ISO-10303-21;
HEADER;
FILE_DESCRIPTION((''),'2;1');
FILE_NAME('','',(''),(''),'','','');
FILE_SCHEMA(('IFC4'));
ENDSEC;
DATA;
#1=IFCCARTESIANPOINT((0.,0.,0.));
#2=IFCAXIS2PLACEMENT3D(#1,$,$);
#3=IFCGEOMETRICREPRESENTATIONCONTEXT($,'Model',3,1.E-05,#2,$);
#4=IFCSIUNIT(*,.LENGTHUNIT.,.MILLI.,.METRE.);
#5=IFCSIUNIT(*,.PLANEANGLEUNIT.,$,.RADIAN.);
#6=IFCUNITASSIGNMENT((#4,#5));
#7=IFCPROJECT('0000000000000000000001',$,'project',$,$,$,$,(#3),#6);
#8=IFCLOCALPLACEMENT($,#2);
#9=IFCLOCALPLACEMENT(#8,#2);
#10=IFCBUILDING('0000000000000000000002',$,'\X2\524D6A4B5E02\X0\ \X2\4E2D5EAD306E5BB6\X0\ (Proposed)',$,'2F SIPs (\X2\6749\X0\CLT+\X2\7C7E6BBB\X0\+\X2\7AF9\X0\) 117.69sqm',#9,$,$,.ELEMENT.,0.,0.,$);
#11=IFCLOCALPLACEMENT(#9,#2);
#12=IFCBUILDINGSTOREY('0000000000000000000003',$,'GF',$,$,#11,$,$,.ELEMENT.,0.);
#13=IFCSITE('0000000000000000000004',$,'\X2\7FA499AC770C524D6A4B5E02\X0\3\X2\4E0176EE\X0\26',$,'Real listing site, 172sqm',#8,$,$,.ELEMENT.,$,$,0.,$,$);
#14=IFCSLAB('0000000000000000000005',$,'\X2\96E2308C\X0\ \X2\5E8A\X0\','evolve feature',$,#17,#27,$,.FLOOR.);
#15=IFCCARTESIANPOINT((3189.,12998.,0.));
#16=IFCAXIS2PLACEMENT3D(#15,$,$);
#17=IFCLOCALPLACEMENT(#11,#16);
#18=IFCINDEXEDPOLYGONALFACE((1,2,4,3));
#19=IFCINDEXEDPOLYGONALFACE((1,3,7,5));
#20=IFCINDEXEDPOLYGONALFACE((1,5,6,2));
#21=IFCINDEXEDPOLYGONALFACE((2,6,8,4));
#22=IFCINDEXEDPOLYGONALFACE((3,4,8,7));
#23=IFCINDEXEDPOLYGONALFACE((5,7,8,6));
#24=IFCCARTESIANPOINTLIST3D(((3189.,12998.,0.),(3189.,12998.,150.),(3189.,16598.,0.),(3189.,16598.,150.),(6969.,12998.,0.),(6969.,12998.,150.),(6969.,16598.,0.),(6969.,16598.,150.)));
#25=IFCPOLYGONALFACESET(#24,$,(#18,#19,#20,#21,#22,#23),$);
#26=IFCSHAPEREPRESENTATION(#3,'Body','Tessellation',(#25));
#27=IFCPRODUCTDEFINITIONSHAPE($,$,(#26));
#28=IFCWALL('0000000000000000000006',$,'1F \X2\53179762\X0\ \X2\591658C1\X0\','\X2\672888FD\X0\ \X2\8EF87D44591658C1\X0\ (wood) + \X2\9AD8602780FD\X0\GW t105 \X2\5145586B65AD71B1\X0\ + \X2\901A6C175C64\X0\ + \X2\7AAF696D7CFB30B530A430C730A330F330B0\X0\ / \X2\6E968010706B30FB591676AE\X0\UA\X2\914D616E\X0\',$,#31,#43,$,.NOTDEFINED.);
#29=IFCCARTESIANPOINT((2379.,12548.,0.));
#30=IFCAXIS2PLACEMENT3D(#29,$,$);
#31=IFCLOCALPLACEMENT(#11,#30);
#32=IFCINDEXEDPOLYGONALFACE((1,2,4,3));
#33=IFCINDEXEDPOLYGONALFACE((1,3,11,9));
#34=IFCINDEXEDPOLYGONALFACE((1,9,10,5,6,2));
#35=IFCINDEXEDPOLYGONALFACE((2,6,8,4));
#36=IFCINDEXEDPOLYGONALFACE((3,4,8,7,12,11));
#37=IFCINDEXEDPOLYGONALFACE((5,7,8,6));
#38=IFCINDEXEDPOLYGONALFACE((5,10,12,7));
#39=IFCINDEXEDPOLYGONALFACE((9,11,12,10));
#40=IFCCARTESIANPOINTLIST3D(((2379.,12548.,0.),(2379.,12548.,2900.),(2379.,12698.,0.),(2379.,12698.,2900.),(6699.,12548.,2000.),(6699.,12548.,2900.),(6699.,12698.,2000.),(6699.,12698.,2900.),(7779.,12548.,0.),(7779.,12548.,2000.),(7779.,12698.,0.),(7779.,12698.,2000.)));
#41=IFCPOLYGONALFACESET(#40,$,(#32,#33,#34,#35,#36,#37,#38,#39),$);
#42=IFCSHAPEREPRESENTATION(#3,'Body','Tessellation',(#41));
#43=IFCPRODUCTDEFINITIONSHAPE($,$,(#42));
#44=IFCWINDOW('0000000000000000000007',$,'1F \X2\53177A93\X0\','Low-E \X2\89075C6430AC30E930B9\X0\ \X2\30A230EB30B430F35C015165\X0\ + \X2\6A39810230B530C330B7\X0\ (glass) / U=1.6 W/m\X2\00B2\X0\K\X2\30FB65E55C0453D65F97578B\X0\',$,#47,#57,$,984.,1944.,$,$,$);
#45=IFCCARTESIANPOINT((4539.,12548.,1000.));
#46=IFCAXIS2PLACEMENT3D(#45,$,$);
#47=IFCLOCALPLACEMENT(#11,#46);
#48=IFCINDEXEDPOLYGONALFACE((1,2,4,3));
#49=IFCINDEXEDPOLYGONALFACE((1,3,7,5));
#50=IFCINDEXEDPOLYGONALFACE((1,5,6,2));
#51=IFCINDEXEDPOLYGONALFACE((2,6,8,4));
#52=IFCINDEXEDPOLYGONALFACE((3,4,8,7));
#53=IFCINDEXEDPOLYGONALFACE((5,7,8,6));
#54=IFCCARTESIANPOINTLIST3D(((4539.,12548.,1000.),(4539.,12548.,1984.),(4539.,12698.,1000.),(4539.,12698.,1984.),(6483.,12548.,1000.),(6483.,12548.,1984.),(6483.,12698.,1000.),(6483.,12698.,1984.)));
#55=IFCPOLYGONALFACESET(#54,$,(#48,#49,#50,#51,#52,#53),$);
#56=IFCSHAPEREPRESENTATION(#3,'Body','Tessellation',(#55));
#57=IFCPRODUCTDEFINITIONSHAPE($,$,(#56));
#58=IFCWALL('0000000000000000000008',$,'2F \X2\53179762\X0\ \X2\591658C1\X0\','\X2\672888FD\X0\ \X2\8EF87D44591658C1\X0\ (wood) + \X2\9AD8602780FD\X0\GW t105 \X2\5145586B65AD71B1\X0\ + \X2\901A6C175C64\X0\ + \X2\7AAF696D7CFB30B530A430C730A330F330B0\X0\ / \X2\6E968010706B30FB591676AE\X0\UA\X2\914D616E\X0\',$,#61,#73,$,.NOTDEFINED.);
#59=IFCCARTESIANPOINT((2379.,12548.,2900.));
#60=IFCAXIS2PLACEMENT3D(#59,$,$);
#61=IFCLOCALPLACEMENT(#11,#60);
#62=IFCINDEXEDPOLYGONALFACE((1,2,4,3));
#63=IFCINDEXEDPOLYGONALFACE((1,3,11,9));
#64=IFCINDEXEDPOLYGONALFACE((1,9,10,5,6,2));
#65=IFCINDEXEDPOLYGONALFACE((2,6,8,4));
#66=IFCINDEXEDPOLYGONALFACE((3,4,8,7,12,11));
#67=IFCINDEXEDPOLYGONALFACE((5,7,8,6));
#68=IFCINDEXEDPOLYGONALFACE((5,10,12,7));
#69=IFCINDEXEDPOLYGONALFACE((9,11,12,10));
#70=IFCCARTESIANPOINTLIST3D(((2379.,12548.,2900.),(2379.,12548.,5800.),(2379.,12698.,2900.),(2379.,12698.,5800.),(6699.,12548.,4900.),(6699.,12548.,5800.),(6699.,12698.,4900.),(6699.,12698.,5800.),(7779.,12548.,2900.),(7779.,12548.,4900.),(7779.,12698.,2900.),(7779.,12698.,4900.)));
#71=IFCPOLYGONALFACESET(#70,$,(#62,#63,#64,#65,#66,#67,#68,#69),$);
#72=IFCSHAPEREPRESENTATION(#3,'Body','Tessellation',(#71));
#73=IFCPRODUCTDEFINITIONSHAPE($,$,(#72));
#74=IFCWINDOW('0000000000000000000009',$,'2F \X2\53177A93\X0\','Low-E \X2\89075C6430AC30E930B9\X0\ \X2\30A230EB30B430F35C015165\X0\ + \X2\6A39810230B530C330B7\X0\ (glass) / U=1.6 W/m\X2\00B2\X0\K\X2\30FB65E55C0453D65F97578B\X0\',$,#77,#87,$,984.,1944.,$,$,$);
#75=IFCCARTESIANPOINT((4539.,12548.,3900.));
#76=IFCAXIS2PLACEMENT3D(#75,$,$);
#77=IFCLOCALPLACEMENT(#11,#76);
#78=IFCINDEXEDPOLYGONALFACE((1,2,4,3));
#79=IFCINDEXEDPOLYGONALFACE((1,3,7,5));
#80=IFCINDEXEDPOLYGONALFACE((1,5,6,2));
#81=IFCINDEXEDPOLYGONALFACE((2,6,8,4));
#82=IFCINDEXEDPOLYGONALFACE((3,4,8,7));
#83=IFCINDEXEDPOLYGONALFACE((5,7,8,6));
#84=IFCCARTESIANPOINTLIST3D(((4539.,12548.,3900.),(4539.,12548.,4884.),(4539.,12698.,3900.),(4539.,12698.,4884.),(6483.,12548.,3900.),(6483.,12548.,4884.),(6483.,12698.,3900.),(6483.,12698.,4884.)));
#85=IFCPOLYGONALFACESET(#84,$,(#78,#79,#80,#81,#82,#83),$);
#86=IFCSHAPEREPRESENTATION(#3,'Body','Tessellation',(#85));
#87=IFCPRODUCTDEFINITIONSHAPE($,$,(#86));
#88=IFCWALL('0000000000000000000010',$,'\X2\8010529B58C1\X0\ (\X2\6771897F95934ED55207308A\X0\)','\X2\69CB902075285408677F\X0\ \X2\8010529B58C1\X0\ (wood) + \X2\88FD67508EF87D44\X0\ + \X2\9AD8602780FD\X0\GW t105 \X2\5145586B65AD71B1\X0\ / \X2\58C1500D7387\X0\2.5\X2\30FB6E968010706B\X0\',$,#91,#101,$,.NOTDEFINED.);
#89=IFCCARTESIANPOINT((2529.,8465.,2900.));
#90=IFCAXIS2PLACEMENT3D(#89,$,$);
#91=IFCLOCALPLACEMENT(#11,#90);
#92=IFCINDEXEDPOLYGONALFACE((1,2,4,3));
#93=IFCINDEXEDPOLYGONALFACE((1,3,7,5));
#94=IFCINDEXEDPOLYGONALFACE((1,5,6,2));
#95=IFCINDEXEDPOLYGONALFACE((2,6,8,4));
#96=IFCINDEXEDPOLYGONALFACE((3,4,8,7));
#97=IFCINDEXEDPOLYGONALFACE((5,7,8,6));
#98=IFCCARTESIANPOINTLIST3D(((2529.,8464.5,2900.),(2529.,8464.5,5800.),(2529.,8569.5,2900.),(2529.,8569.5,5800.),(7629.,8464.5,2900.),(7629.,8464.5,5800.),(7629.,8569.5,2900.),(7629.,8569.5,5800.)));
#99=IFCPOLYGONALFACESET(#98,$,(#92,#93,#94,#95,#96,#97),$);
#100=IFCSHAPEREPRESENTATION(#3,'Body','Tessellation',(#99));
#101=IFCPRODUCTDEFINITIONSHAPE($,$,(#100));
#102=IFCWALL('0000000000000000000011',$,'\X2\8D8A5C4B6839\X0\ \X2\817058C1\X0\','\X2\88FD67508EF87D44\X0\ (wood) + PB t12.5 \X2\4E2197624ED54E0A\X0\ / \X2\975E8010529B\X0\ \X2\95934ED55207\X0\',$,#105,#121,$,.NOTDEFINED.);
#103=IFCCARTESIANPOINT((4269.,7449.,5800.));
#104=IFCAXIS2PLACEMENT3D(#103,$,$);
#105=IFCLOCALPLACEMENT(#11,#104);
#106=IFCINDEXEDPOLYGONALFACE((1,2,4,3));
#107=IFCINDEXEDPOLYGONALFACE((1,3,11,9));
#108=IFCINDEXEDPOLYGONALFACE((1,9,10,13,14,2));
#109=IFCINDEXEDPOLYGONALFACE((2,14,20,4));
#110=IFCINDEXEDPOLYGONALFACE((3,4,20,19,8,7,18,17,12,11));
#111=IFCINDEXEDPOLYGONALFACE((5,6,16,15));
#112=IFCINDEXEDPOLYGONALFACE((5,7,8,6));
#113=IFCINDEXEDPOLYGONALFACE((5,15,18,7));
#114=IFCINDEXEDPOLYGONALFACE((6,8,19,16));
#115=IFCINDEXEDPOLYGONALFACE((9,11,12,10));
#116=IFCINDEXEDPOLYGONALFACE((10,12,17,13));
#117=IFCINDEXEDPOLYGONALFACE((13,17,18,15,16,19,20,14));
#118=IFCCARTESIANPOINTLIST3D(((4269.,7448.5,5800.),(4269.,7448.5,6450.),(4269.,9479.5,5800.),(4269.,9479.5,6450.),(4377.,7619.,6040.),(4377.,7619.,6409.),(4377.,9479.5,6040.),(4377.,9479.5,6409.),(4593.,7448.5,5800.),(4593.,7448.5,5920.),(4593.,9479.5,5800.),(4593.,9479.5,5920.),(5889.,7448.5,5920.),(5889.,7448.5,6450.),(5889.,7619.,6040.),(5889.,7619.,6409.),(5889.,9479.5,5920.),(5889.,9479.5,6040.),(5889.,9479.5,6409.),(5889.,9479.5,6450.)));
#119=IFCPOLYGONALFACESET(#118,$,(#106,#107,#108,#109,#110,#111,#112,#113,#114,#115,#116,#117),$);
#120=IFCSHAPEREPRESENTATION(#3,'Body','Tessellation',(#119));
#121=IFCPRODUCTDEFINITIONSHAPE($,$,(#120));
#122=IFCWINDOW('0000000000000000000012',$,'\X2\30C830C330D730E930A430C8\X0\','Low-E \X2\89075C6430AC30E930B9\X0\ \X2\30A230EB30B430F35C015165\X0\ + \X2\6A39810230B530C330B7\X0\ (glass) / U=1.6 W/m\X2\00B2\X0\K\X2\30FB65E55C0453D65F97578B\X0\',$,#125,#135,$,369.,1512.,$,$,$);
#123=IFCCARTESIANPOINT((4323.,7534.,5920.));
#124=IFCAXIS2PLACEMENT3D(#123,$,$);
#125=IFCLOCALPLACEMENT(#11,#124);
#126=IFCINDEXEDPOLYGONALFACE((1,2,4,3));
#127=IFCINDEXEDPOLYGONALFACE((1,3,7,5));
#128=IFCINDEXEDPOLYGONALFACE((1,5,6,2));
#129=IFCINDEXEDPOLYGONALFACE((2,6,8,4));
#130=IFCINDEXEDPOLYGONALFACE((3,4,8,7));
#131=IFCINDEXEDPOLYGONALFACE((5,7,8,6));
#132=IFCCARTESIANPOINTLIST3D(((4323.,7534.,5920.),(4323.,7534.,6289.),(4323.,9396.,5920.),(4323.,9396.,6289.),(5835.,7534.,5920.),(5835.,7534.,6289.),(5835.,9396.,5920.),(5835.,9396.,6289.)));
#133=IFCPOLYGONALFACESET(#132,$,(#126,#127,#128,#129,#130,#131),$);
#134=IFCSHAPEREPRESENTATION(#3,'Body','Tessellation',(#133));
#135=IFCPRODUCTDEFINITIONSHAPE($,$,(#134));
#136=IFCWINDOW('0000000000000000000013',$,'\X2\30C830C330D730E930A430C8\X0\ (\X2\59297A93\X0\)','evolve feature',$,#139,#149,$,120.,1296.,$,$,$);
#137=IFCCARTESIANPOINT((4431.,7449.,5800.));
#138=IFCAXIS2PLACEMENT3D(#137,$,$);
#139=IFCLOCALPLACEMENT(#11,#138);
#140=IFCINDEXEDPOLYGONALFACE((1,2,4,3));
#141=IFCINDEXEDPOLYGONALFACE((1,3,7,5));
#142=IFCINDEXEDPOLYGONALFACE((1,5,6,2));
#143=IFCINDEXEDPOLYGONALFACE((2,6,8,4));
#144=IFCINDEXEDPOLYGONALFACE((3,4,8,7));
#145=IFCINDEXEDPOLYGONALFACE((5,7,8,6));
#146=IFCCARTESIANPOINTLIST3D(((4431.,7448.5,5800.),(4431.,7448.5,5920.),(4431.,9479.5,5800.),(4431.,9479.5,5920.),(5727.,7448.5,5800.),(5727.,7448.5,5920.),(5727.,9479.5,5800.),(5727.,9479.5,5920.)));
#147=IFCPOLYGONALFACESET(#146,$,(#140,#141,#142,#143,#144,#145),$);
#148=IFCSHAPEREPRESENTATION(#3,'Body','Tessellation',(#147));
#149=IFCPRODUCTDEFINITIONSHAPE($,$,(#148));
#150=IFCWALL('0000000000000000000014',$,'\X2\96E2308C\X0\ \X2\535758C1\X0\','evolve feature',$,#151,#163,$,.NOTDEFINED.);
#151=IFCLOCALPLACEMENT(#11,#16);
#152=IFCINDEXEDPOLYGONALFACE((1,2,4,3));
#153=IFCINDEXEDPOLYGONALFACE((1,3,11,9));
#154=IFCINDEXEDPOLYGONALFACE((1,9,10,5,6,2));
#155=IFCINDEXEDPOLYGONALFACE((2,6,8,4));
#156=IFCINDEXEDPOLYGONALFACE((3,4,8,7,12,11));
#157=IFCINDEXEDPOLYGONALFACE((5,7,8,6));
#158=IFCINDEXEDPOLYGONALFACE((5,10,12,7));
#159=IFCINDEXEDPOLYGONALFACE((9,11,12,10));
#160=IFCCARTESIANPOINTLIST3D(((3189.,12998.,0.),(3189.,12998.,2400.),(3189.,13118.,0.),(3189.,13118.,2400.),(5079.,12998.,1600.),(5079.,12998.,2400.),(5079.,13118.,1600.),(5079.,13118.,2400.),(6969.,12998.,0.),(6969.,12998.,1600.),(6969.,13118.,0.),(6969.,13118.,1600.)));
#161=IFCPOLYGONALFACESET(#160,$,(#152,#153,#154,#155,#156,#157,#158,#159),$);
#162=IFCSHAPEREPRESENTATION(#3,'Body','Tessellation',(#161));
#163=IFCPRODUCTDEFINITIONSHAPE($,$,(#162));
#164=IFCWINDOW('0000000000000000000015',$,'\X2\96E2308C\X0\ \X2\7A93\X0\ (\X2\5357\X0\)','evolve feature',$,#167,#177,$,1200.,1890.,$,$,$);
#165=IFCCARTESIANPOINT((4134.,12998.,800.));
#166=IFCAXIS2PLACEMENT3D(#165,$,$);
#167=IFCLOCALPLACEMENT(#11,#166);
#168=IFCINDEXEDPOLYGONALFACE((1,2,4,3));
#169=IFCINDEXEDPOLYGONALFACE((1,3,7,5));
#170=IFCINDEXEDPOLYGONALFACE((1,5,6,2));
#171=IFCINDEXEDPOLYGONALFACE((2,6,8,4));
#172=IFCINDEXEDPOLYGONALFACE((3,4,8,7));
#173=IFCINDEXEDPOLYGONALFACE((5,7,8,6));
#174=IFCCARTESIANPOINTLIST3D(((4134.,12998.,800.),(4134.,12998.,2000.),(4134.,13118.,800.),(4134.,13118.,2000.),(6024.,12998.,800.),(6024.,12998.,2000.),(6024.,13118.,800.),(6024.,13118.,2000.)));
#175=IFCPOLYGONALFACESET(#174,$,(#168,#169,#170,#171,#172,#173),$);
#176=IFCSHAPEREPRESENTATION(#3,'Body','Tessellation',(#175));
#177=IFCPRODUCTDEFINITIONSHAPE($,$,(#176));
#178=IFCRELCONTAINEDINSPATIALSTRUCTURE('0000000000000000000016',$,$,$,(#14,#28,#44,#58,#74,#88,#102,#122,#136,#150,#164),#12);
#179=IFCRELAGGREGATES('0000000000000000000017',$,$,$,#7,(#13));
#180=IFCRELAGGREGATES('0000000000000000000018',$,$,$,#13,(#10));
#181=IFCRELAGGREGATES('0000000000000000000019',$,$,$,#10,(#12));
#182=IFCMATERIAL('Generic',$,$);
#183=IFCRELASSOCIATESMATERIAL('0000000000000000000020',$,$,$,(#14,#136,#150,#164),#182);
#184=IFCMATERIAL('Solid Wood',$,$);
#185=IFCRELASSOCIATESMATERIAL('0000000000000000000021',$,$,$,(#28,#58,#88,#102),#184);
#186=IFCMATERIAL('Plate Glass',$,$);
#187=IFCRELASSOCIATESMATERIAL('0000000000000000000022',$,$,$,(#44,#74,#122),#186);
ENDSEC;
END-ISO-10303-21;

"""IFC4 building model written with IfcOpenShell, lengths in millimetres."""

from ifc_helpers import new_model, si_unit, frame, frame_2d, origin, place, context, project, spatial, rectangle, extrude, material, element, fill, save


model = new_model("IFC4")

# Units and contexts
model_context = context("Model", 3, precision=1e-05, world=origin())
ifc_project = project(units=[si_unit("LENGTHUNIT", "METRE", prefix="MILLI"), si_unit("PLANEANGLEUNIT", "RADIAN")], contexts=[model_context])

# Site, building, storey
site_placement = place(None, origin())
site = spatial("IfcSite", under=ifc_project, at=site_placement, Name="群馬県前橋市3丁目26", ObjectType="Real listing site, 172sqm", CompositionType="ELEMENT", RefElevation=0.0)
building_placement = place(site_placement, origin())
building = spatial("IfcBuilding", under=site, at=building_placement, Name="前橋市 中庭の家 (Proposed)", ObjectType="2F SIPs (杉CLT+籾殻+竹) 117.69sqm", CompositionType="ELEMENT", ElevationOfRefHeight=0.0, ElevationOfTerrain=0.0)
storey_placement = place(building_placement, origin())
storey = spatial("IfcBuildingStorey", under=building, at=storey_placement, Name="GF", CompositionType="ELEMENT", Elevation=0.0)

# Slab
ifc_material_1 = material(Name="Generic")
slab_placement = place(storey_placement, frame((3189.0, 12998.0, 0.0)))
element("IfcSlab", 1, at=slab_placement, inside=storey, material=ifc_material_1, Name="離れ 床", Description="evolve feature", PredefinedType="FLOOR", context=model_context, shape_type="SweptSolid", body=[
    extrude(rectangle(XDim=3780.0, YDim=3600.0, at=frame_2d((1890.0, 1800.0))), frame((3189.0, 12998.0, 0.0)), (0.0, 0.0, 1.0), 150.0),
])

# Wall, opening, window
ifc_material_2 = material(Name="Solid Wood")
wall_1_placement = place(storey_placement, frame((2379.0, 12548.0, 0.0)))
wall_1 = element("IfcWall", 2, at=wall_1_placement, inside=storey, material=ifc_material_2, Name="1F 北面 外壁", Description="木製 軸組外壁 (wood) + 高性能GW t105 充填断熱 + 通気層 + 窯業系サイディング / 準耐火・外皮UA配慮", PredefinedType="NOTDEFINED", context=model_context, shape_type="SweptSolid", body=[
    extrude(rectangle(XDim=5400.0, YDim=150.0, at=frame_2d((2700.0, 75.0))), frame((2379.0, 12548.0, 0.0)), (0.0, 0.0, 1.0), 2900.0),
])
opening_1_placement = place(storey_placement, frame((4539.0, 12548.0, 1000.0)))
opening_1 = element("IfcOpeningElement", 3, at=opening_1_placement, cuts=wall_1, PredefinedType="NOTDEFINED", context=model_context, shape_type="SweptSolid", body=[
    extrude(rectangle(XDim=1944.0, YDim=150.0, at=frame_2d((972.0, 75.0))), frame((4539.0, 12548.0, 1000.0)), (0.0, 0.0, 1.0), 984.0),
])
ifc_material_3 = material(Name="Plate Glass")
window_1_placement = place(storey_placement, frame((4539.0, 12548.0, 1000.0)))
window_1 = element("IfcWindow", 4, at=window_1_placement, inside=storey, material=ifc_material_3, Name="1F 北窓", Description="Low-E 複層ガラス アルゴン封入 + 樹脂サッシ (glass) / U=1.6 W/m²K・日射取得型", OverallHeight=984.0, OverallWidth=1944.0, context=model_context, shape_type="SweptSolid", body=[
    extrude(rectangle(XDim=1944.0, YDim=150.0, at=frame_2d((972.0, 75.0))), frame((4539.0, 12548.0, 1000.0)), (0.0, 0.0, 1.0), 984.0),
])
fill(opening_1, window_1)

# Wall, opening, window
wall_2_placement = place(storey_placement, frame((2379.0, 12548.0, 2900.0)))
wall_2 = element("IfcWall", 5, at=wall_2_placement, inside=storey, material=ifc_material_2, Name="2F 北面 外壁", Description="木製 軸組外壁 (wood) + 高性能GW t105 充填断熱 + 通気層 + 窯業系サイディング / 準耐火・外皮UA配慮", PredefinedType="NOTDEFINED", context=model_context, shape_type="SweptSolid", body=[
    extrude(rectangle(XDim=5400.0, YDim=150.0, at=frame_2d((2700.0, 75.0))), frame((2379.0, 12548.0, 2900.0)), (0.0, 0.0, 1.0), 2900.0),
])
opening_2_placement = place(storey_placement, frame((4539.0, 12548.0, 3900.0)))
opening_2 = element("IfcOpeningElement", 6, at=opening_2_placement, cuts=wall_2, PredefinedType="NOTDEFINED", context=model_context, shape_type="SweptSolid", body=[
    extrude(rectangle(XDim=1944.0, YDim=150.0, at=frame_2d((972.0, 75.0))), frame((4539.0, 12548.0, 3900.0)), (0.0, 0.0, 1.0), 984.0),
])
window_2_placement = place(storey_placement, frame((4539.0, 12548.0, 3900.0)))
window_2 = element("IfcWindow", 7, at=window_2_placement, inside=storey, material=ifc_material_3, Name="2F 北窓", Description="Low-E 複層ガラス アルゴン封入 + 樹脂サッシ (glass) / U=1.6 W/m²K・日射取得型", OverallHeight=984.0, OverallWidth=1944.0, context=model_context, shape_type="SweptSolid", body=[
    extrude(rectangle(XDim=1944.0, YDim=150.0, at=frame_2d((972.0, 75.0))), frame((4539.0, 12548.0, 3900.0)), (0.0, 0.0, 1.0), 984.0),
])
fill(opening_2, window_2)

# Wall
wall_3_placement = place(storey_placement, frame((2529.0, 8465.0, 2900.0)))
element("IfcWall", 8, at=wall_3_placement, inside=storey, material=ifc_material_2, Name="耐力壁 (東西間仕切り)", Description="構造用合板 耐力壁 (wood) + 製材軸組 + 高性能GW t105 充填断熱 / 壁倍率2.5・準耐火", PredefinedType="NOTDEFINED", context=model_context, shape_type="SweptSolid", body=[
    extrude(rectangle(XDim=5100.0, YDim=105.0, at=frame_2d((2550.0, 52.0))), frame((2529.0, 8465.0, 2900.0)), (0.0, 0.0, 1.0), 2900.0),
])

# Wall, openings, windows
wall_4_placement = place(storey_placement, frame((4269.0, 7449.0, 5800.0)))
wall_4 = element("IfcWall", 9, at=wall_4_placement, inside=storey, material=ifc_material_2, Name="越屋根 腰壁", Description="製材軸組 (wood) + PB t12.5 両面仕上 / 非耐力 間仕切", PredefinedType="NOTDEFINED", context=model_context, shape_type="SweptSolid", body=[
    extrude(rectangle(XDim=1620.0, YDim=2031.0, at=frame_2d((810.0, 1015.0))), frame((4269.0, 7449.0, 5800.0)), (0.0, 0.0, 1.0), 650.0),
])
opening_3_placement = place(storey_placement, frame((4323.0, 7534.0, 5920.0)))
opening_3 = element("IfcOpeningElement", 10, at=opening_3_placement, cuts=wall_4, PredefinedType="NOTDEFINED", context=model_context, shape_type="SweptSolid", body=[
    extrude(rectangle(XDim=1512.0, YDim=1862.0, at=frame_2d((756.0, 931.0))), frame((4323.0, 7534.0, 5920.0)), (0.0, 0.0, 1.0), 369.0),
])
opening_4_placement = place(storey_placement, frame((4431.0, 7449.0, 5800.0)))
opening_4 = element("IfcOpeningElement", 11, at=opening_4_placement, cuts=wall_4, PredefinedType="NOTDEFINED", context=model_context, shape_type="SweptSolid", body=[
    extrude(rectangle(XDim=1296.0, YDim=2031.0, at=frame_2d((648.0, 1015.0))), frame((4431.0, 7449.0, 5800.0)), (0.0, 0.0, 1.0), 120.0),
])
window_3_placement = place(storey_placement, frame((4323.0, 7534.0, 5920.0)))
window_3 = element("IfcWindow", 12, at=window_3_placement, inside=storey, material=ifc_material_3, Name="トップライト", Description="Low-E 複層ガラス アルゴン封入 + 樹脂サッシ (glass) / U=1.6 W/m²K・日射取得型", OverallHeight=369.0, OverallWidth=1512.0, context=model_context, shape_type="SweptSolid", body=[
    extrude(rectangle(XDim=1512.0, YDim=1862.0, at=frame_2d((756.0, 931.0))), frame((4323.0, 7534.0, 5920.0)), (0.0, 0.0, 1.0), 369.0),
])
fill(opening_3, window_3)
window_4_placement = place(storey_placement, frame((4431.0, 7449.0, 5800.0)))
window_4 = element("IfcWindow", 13, at=window_4_placement, inside=storey, material=ifc_material_1, Name="トップライト (天窓)", Description="evolve feature", OverallHeight=120.0, OverallWidth=1296.0, context=model_context, shape_type="SweptSolid", body=[
    extrude(rectangle(XDim=1296.0, YDim=2031.0, at=frame_2d((648.0, 1015.0))), frame((4431.0, 7449.0, 5800.0)), (0.0, 0.0, 1.0), 120.0),
])
fill(opening_4, window_4)

# Wall, opening, window
wall_5_placement = place(storey_placement, frame((3189.0, 12998.0, 0.0)))
wall_5 = element("IfcWall", 14, at=wall_5_placement, inside=storey, material=ifc_material_1, Name="離れ 南壁", Description="evolve feature", PredefinedType="NOTDEFINED", context=model_context, shape_type="SweptSolid", body=[
    extrude(rectangle(XDim=3780.0, YDim=120.0, at=frame_2d((1890.0, 60.0))), frame((3189.0, 12998.0, 0.0)), (0.0, 0.0, 1.0), 2400.0),
])
opening_5_placement = place(storey_placement, frame((4134.0, 12998.0, 800.0)))
opening_5 = element("IfcOpeningElement", 15, at=opening_5_placement, cuts=wall_5, PredefinedType="NOTDEFINED", context=model_context, shape_type="SweptSolid", body=[
    extrude(rectangle(XDim=1890.0, YDim=120.0, at=frame_2d((945.0, 60.0))), frame((4134.0, 12998.0, 800.0)), (0.0, 0.0, 1.0), 1200.0),
])
window_5_placement = place(storey_placement, frame((4134.0, 12998.0, 800.0)))
window_5 = element("IfcWindow", 16, at=window_5_placement, inside=storey, material=ifc_material_1, Name="離れ 窓 (南)", Description="evolve feature", OverallHeight=1200.0, OverallWidth=1890.0, context=model_context, shape_type="SweptSolid", body=[
    extrude(rectangle(XDim=1890.0, YDim=120.0, at=frame_2d((945.0, 60.0))), frame((4134.0, 12998.0, 800.0)), (0.0, 0.0, 1.0), 1200.0),
])
fill(opening_5, window_5)

save(model, "model.ifc")
